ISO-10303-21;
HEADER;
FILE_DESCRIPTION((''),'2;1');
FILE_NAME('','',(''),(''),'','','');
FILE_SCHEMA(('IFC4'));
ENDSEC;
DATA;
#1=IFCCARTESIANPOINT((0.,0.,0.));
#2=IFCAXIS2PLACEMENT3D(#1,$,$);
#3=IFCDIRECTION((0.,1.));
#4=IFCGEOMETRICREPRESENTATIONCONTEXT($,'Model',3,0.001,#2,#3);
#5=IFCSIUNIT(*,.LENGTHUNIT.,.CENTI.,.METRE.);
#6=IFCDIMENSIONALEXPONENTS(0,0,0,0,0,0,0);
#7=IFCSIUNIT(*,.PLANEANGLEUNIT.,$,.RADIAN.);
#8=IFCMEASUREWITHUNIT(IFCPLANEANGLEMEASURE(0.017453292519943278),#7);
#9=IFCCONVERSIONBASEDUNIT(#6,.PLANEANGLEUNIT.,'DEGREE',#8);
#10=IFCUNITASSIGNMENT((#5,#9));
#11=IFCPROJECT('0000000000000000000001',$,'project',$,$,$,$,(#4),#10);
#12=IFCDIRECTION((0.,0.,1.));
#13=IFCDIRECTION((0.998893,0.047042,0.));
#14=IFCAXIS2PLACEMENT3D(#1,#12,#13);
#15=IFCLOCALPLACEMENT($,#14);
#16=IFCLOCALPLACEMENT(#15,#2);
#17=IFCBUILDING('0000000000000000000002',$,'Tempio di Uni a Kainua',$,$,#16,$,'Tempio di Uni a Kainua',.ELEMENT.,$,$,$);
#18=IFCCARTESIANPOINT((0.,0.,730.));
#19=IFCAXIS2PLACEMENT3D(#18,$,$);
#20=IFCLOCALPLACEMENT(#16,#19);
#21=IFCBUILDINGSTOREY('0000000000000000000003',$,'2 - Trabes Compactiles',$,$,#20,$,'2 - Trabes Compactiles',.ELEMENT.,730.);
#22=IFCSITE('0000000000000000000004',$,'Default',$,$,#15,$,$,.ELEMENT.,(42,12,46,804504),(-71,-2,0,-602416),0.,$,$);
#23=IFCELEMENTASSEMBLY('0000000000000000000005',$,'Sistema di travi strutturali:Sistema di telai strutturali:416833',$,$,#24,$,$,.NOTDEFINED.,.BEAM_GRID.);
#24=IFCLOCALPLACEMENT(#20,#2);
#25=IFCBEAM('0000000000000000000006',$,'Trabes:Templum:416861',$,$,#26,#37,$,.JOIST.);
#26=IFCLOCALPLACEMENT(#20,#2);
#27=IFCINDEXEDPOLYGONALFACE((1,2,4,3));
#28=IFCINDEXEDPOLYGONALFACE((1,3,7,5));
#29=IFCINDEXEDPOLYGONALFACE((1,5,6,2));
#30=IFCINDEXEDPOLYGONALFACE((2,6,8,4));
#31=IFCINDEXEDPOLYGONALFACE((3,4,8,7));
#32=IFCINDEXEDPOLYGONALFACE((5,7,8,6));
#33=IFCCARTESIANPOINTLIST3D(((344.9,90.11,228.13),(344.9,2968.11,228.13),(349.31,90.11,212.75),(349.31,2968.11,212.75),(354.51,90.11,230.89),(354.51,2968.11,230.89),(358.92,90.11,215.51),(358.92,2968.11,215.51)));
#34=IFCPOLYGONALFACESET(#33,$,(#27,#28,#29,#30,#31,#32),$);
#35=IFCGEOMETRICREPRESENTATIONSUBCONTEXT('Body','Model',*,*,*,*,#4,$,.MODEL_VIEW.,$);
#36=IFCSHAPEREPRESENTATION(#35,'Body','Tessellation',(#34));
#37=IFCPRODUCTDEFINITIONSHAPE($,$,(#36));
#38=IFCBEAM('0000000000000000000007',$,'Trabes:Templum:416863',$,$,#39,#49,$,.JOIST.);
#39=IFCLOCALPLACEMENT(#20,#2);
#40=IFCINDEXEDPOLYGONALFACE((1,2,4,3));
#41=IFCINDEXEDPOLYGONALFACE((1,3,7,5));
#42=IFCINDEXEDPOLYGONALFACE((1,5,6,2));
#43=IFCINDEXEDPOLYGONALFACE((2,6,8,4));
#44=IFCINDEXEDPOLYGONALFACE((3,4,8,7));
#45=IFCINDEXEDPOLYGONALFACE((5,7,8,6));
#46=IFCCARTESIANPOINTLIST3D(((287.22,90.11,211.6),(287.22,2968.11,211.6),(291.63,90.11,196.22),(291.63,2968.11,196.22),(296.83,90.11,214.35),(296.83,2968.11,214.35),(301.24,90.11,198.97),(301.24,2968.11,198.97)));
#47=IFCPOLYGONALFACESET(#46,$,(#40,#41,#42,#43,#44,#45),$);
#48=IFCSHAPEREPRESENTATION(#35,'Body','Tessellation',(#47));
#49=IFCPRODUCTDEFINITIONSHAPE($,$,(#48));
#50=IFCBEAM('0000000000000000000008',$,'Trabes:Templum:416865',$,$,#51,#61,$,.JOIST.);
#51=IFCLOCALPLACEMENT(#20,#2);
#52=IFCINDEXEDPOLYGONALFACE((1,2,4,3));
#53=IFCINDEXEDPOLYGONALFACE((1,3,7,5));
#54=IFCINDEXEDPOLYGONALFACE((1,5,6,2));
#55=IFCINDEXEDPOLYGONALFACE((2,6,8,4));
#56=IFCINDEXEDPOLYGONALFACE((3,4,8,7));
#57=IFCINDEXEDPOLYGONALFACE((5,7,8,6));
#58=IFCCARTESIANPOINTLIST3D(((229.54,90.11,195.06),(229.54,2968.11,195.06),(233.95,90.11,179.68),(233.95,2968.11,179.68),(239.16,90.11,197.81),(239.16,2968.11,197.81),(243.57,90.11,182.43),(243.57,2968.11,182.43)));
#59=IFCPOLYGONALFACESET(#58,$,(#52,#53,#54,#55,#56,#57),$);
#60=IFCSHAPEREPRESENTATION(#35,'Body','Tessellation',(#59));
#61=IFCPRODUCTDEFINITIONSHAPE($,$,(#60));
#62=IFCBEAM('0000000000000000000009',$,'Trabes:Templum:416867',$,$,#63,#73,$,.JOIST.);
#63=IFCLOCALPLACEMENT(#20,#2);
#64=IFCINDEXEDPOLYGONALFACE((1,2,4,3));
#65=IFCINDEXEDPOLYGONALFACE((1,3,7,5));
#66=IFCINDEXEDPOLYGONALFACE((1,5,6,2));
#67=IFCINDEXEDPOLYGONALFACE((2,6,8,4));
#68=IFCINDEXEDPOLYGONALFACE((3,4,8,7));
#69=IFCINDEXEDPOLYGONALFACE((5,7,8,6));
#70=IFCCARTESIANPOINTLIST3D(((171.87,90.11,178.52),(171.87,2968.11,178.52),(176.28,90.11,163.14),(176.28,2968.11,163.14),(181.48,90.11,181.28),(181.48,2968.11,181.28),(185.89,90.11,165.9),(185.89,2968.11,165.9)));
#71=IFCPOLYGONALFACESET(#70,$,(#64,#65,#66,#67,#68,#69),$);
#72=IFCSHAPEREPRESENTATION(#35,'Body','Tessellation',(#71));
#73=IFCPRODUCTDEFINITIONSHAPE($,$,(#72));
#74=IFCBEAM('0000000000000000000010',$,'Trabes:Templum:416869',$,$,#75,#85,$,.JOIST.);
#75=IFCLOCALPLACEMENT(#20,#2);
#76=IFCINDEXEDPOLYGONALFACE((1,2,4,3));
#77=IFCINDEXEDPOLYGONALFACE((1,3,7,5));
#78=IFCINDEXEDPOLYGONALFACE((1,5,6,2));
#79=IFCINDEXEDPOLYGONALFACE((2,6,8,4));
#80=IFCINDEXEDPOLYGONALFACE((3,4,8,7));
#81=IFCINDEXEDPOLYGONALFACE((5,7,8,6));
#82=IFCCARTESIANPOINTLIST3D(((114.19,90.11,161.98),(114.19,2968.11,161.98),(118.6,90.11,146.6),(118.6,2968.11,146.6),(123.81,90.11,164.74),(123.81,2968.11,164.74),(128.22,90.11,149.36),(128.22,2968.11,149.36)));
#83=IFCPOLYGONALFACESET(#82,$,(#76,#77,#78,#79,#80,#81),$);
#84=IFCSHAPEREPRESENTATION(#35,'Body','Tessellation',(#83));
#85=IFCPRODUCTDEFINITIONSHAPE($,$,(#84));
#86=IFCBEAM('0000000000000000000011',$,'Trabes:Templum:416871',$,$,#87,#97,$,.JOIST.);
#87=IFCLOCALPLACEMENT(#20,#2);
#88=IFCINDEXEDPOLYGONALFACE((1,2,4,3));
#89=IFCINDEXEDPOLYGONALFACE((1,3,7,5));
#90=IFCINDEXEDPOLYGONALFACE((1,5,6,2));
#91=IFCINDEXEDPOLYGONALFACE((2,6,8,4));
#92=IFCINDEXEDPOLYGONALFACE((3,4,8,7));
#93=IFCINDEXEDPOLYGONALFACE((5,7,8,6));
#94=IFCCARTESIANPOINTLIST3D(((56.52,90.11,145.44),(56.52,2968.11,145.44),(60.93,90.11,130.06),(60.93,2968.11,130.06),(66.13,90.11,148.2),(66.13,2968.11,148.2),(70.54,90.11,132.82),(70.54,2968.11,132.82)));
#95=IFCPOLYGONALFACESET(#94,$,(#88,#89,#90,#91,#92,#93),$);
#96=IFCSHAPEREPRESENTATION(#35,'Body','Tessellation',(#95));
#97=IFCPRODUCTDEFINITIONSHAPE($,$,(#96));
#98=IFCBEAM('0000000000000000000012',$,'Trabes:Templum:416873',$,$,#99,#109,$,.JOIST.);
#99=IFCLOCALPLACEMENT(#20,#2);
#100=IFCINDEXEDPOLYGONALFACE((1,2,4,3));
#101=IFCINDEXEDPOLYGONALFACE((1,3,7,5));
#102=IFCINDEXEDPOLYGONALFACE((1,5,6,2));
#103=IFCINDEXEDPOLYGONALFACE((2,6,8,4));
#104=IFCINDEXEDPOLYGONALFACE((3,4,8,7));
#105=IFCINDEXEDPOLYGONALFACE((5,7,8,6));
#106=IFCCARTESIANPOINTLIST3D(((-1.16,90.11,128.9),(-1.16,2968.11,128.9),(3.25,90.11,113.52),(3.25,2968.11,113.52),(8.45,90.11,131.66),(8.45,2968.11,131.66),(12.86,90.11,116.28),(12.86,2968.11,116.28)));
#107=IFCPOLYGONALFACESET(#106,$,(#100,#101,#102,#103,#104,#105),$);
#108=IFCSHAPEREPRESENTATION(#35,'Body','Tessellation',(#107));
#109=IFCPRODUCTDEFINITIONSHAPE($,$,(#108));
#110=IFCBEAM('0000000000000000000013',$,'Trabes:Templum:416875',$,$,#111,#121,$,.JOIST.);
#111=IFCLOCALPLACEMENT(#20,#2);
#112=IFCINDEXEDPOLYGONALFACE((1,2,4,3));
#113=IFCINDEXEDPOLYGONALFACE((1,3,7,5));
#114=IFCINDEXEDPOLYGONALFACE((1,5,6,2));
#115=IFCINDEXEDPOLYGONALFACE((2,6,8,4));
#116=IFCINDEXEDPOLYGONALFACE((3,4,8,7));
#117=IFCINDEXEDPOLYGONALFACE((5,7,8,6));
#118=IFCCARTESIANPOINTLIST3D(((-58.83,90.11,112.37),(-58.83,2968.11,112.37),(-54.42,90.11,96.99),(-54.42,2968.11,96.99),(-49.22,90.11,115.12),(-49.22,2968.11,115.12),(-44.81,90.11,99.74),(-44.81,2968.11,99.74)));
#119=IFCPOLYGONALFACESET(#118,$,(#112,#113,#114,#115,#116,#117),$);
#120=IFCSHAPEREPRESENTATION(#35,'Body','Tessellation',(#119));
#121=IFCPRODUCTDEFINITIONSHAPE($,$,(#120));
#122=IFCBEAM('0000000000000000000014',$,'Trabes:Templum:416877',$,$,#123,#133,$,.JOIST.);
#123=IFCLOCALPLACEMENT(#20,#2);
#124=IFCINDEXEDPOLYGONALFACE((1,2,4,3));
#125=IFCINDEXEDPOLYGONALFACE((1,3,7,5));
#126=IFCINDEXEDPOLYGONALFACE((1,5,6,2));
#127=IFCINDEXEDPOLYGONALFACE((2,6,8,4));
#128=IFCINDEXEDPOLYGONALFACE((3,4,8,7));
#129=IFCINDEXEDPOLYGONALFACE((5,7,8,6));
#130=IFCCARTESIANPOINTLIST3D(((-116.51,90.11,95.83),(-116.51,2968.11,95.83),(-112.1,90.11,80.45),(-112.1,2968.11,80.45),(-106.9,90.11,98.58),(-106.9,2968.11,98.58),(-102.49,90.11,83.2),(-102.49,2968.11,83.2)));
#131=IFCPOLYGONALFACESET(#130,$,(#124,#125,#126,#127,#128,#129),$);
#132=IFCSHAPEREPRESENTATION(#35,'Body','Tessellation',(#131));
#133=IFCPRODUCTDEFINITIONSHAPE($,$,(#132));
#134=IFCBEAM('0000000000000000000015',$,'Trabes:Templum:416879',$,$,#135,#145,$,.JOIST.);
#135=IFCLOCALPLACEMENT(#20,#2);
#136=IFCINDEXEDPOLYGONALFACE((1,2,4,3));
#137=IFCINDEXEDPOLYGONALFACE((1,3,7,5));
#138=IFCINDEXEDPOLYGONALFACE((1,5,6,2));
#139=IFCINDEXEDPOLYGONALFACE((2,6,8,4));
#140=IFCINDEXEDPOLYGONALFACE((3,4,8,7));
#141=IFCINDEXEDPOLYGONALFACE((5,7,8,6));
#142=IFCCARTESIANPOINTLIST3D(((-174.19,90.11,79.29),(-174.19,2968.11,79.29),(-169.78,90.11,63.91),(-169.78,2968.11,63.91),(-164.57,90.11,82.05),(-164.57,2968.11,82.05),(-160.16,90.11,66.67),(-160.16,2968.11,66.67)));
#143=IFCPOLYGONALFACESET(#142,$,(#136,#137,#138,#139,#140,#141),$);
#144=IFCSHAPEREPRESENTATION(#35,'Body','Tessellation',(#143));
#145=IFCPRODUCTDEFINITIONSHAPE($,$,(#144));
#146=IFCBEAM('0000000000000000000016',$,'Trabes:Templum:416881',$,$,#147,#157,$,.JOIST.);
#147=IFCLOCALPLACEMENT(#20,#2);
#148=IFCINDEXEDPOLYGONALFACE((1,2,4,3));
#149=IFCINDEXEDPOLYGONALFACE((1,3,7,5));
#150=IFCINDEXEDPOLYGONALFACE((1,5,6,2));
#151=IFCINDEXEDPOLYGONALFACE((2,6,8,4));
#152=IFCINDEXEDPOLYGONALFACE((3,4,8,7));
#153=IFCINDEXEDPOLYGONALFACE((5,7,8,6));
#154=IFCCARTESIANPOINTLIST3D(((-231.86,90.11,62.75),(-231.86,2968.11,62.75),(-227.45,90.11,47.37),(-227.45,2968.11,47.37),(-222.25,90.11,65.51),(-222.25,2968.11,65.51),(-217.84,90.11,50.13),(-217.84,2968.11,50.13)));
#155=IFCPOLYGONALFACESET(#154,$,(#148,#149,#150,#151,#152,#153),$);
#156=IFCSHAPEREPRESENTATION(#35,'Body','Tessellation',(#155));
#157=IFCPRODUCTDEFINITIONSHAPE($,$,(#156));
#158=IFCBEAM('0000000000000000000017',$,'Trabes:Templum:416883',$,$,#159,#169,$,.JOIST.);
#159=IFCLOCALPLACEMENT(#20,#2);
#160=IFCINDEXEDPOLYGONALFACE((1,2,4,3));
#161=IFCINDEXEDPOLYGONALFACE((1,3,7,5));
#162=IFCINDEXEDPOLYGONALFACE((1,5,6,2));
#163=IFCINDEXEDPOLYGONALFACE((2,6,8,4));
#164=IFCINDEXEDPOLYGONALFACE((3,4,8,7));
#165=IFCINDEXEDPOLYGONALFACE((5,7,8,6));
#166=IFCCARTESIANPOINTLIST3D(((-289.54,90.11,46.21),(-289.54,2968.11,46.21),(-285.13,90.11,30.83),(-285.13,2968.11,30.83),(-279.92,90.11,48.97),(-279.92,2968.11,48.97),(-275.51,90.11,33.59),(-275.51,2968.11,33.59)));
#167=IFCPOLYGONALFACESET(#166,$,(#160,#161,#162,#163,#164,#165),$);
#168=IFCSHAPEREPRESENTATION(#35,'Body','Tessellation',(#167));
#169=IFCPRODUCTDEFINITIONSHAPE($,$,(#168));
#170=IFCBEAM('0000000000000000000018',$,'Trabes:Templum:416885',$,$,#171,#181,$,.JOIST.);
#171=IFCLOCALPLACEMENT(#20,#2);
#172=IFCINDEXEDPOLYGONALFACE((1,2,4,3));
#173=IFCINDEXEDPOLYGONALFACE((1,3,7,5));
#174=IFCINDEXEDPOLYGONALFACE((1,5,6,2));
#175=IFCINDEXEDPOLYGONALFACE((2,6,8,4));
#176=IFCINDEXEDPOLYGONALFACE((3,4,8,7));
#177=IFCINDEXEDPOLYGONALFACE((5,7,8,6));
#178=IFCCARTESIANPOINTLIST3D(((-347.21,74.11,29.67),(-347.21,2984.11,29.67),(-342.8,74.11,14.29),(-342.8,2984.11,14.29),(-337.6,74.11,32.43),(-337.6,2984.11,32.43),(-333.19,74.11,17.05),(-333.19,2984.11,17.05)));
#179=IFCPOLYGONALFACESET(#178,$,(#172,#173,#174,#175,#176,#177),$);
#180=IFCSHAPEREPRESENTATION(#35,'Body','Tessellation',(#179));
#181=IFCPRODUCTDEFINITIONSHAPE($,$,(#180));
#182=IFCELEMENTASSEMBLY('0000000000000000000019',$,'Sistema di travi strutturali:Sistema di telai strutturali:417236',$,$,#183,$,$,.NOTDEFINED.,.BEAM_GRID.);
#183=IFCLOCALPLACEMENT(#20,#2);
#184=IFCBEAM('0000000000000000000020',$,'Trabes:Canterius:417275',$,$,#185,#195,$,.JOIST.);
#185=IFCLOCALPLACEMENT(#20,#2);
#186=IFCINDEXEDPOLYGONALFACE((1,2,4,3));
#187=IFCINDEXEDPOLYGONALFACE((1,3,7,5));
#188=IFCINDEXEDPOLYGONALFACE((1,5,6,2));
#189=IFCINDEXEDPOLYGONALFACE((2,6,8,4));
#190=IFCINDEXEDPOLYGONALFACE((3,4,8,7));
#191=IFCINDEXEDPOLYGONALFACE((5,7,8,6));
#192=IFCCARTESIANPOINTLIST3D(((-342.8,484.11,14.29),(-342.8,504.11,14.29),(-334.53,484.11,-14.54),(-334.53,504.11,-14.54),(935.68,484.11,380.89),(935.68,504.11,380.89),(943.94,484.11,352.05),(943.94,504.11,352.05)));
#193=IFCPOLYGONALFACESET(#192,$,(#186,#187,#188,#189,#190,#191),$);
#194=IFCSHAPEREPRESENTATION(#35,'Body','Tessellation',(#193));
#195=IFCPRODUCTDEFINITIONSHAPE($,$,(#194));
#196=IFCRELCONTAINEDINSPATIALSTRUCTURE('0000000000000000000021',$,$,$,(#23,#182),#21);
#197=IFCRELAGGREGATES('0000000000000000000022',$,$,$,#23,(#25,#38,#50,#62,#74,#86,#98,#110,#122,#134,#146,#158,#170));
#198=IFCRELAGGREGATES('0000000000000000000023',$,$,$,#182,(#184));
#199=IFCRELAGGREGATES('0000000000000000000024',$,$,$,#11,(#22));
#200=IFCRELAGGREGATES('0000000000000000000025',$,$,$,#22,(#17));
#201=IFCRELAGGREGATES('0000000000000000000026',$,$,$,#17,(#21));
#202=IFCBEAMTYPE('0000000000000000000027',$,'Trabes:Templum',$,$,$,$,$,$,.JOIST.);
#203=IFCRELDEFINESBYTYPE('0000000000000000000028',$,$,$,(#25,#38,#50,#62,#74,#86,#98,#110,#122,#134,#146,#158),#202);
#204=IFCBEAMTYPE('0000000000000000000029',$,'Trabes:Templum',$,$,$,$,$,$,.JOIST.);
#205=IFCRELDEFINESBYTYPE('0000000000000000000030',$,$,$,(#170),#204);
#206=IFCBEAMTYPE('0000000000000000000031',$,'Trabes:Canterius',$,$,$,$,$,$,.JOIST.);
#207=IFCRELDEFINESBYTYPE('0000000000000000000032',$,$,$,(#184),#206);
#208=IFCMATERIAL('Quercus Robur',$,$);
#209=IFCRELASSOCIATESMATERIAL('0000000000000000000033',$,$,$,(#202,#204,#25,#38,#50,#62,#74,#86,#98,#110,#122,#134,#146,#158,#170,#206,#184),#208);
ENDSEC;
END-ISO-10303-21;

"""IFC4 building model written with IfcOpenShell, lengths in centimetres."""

from ifc_helpers import new_model, entity, si_unit, converted_unit, direction, frame, frame_2d, origin, origin_2d_with_axis, place, context, subcontext, project, spatial, rectangle, extrude, source, transform, mapped, material, material_profile, profile_set, profile_usage, type_object, type_shapes, element, aggregate, save


model = new_model("IFC4")

# Units and contexts
model_context = context("Model", 3, precision=0.001, world=origin(), true_north=direction((0.0, 1.0)))
body_context = subcontext(model_context, "Body", "Model", "MODEL_VIEW")
ifc_project = project(units=[si_unit("LENGTHUNIT", "METRE", prefix="CENTI"), converted_unit("PLANEANGLEUNIT", "DEGREE", entity("IfcPlaneAngleMeasure", 0.017453292519943278), si_unit("PLANEANGLEUNIT", "RADIAN"), dimensions=[0, 0, 0, 0, 0, 0, 0])], contexts=[model_context])

# Site, building, storey
site_placement = place(None, frame((0.0, 0.0, 0.0), z_axis=(0.0, 0.0, 1.0), x_axis=(0.998893, 0.047042, 0.0)))
site = spatial("IfcSite", under=ifc_project, at=site_placement, Name="Default", CompositionType="ELEMENT", RefLatitude=(42, 12, 46, 804504), RefLongitude=(-71, -2, 0, -602416), RefElevation=0.0)
building_placement = place(site_placement, origin())
building = spatial("IfcBuilding", under=site, at=building_placement, Name="Tempio di Uni a Kainua", LongName="Tempio di Uni a Kainua", CompositionType="ELEMENT")
storey_placement = place(building_placement, frame((0.0, 0.0, 730.0)))
storey = spatial("IfcBuildingStorey", under=building, at=storey_placement, Name="2 - Trabes Compactiles", LongName="2 - Trabes Compactiles", CompositionType="ELEMENT", Elevation=730.0)

# Element assemblies, beams
assembly_1_placement = place(storey_placement, origin())
assembly_1 = element("IfcElementAssembly", 1, at=assembly_1_placement, inside=storey, Name="Sistema di travi strutturali:Sistema di telai strutturali:416833", AssemblyPlace="NOTDEFINED", PredefinedType="BEAM_GRID")
ifc_material_1 = material(Name="Quercus Robur")
ifc_material_profile_1 = material_profile(ifc_material_1, rectangle(XDim=2875.46, YDim=10.0, at=origin_2d_with_axis()), Name="Templum")
ifc_profile_set_1 = profile_set([ifc_material_profile_1], Name="Templum")
ifc_profile_usage_1 = profile_usage(ifc_profile_set_1, cardinal=2)
beam_type_1 = type_object("IfcBeamType", Name="Trabes:Templum", PredefinedType="JOIST", material=ifc_profile_set_1)
shared_shape_1 = source(origin(), body_context, "Body", "SweptSolid", [
    extrude(rectangle(XDim=2878.0, YDim=10.0, at=frame_2d((0.0, 0.0), x_axis=(1.0, 0.0))), frame((0.0, 0.0, -8.0)), (0.0, 0.0, 1.0), 16.0),
])
type_shapes(beam_type_1, [shared_shape_1])
beam_1_placement = place(assembly_1_placement, frame((351.91, 1529.11, 221.82), z_axis=(-0.275637, 0.0, 0.961262), x_axis=(0.0, 1.0, 0.0)))
beam_1 = element("IfcBeam", 2, at=beam_1_placement, type_object=beam_type_1, material=ifc_profile_usage_1, Name="Trabes:Templum:416861", PredefinedType="JOIST", context=body_context, shape_type="MappedRepresentation", body=[
    mapped(shared_shape_1, transform((0.0, 0.0, 0.0), scale=1.0)),
])
beam_2_placement = place(assembly_1_placement, frame((294.23, 1529.11, 205.28), z_axis=(-0.275637, 0.0, 0.961262), x_axis=(0.0, 1.0, 0.0)))
beam_2 = element("IfcBeam", 3, at=beam_2_placement, type_object=beam_type_1, material=ifc_profile_usage_1, Name="Trabes:Templum:416863", PredefinedType="JOIST", context=body_context, shape_type="MappedRepresentation", body=[
    mapped(shared_shape_1, transform((0.0, 0.0, 0.0), scale=1.0)),
])
beam_3_placement = place(assembly_1_placement, frame((236.56, 1529.11, 188.75), z_axis=(-0.275637, 0.0, 0.961262), x_axis=(0.0, 1.0, 0.0)))
beam_3 = element("IfcBeam", 4, at=beam_3_placement, type_object=beam_type_1, material=ifc_profile_usage_1, Name="Trabes:Templum:416865", PredefinedType="JOIST", context=body_context, shape_type="MappedRepresentation", body=[
    mapped(shared_shape_1, transform((0.0, 0.0, 0.0), scale=1.0)),
])
beam_4_placement = place(assembly_1_placement, frame((178.88, 1529.11, 172.21), z_axis=(-0.275637, 0.0, 0.961262), x_axis=(0.0, 1.0, 0.0)))
beam_4 = element("IfcBeam", 5, at=beam_4_placement, type_object=beam_type_1, material=ifc_profile_usage_1, Name="Trabes:Templum:416867", PredefinedType="JOIST", context=body_context, shape_type="MappedRepresentation", body=[
    mapped(shared_shape_1, transform((0.0, 0.0, 0.0), scale=1.0)),
])
beam_5_placement = place(assembly_1_placement, frame((121.2, 1529.11, 155.67), z_axis=(-0.275637, 0.0, 0.961262), x_axis=(0.0, 1.0, 0.0)))
beam_5 = element("IfcBeam", 6, at=beam_5_placement, type_object=beam_type_1, material=ifc_profile_usage_1, Name="Trabes:Templum:416869", PredefinedType="JOIST", context=body_context, shape_type="MappedRepresentation", body=[
    mapped(shared_shape_1, transform((0.0, 0.0, 0.0), scale=1.0)),
])
beam_6_placement = place(assembly_1_placement, frame((63.53, 1529.11, 139.13), z_axis=(-0.275637, 0.0, 0.961262), x_axis=(0.0, 1.0, 0.0)))
beam_6 = element("IfcBeam", 7, at=beam_6_placement, type_object=beam_type_1, material=ifc_profile_usage_1, Name="Trabes:Templum:416871", PredefinedType="JOIST", context=body_context, shape_type="MappedRepresentation", body=[
    mapped(shared_shape_1, transform((0.0, 0.0, 0.0), scale=1.0)),
])
beam_7_placement = place(assembly_1_placement, frame((5.85, 1529.11, 122.59), z_axis=(-0.275637, 0.0, 0.961262), x_axis=(0.0, 1.0, 0.0)))
beam_7 = element("IfcBeam", 8, at=beam_7_placement, type_object=beam_type_1, material=ifc_profile_usage_1, Name="Trabes:Templum:416873", PredefinedType="JOIST", context=body_context, shape_type="MappedRepresentation", body=[
    mapped(shared_shape_1, transform((0.0, 0.0, 0.0), scale=1.0)),
])
beam_8_placement = place(assembly_1_placement, frame((-51.82, 1529.11, 106.05), z_axis=(-0.275637, 0.0, 0.961262), x_axis=(0.0, 1.0, 0.0)))
beam_8 = element("IfcBeam", 9, at=beam_8_placement, type_object=beam_type_1, material=ifc_profile_usage_1, Name="Trabes:Templum:416875", PredefinedType="JOIST", context=body_context, shape_type="MappedRepresentation", body=[
    mapped(shared_shape_1, transform((0.0, 0.0, 0.0), scale=1.0)),
])
beam_9_placement = place(assembly_1_placement, frame((-109.5, 1529.11, 89.52), z_axis=(-0.275637, 0.0, 0.961262), x_axis=(0.0, 1.0, 0.0)))
beam_9 = element("IfcBeam", 10, at=beam_9_placement, type_object=beam_type_1, material=ifc_profile_usage_1, Name="Trabes:Templum:416877", PredefinedType="JOIST", context=body_context, shape_type="MappedRepresentation", body=[
    mapped(shared_shape_1, transform((0.0, 0.0, 0.0), scale=1.0)),
])
beam_10_placement = place(assembly_1_placement, frame((-167.17, 1529.11, 72.98), z_axis=(-0.275637, 0.0, 0.961262), x_axis=(0.0, 1.0, 0.0)))
beam_10 = element("IfcBeam", 11, at=beam_10_placement, type_object=beam_type_1, material=ifc_profile_usage_1, Name="Trabes:Templum:416879", PredefinedType="JOIST", context=body_context, shape_type="MappedRepresentation", body=[
    mapped(shared_shape_1, transform((0.0, 0.0, 0.0), scale=1.0)),
])
beam_11_placement = place(assembly_1_placement, frame((-224.85, 1529.11, 56.44), z_axis=(-0.275637, 0.0, 0.961262), x_axis=(0.0, 1.0, 0.0)))
beam_11 = element("IfcBeam", 12, at=beam_11_placement, type_object=beam_type_1, material=ifc_profile_usage_1, Name="Trabes:Templum:416881", PredefinedType="JOIST", context=body_context, shape_type="MappedRepresentation", body=[
    mapped(shared_shape_1, transform((0.0, 0.0, 0.0), scale=1.0)),
])
beam_12_placement = place(assembly_1_placement, frame((-282.53, 1529.11, 39.9), z_axis=(-0.275637, 0.0, 0.961262), x_axis=(0.0, 1.0, 0.0)))
beam_12 = element("IfcBeam", 13, at=beam_12_placement, type_object=beam_type_1, material=ifc_profile_usage_1, Name="Trabes:Templum:416883", PredefinedType="JOIST", context=body_context, shape_type="MappedRepresentation", body=[
    mapped(shared_shape_1, transform((0.0, 0.0, 0.0), scale=1.0)),
])
beam_type_2 = type_object("IfcBeamType", Name="Trabes:Templum", PredefinedType="JOIST", material=ifc_profile_set_1)
shared_shape_2 = source(origin(), body_context, "Body", "SweptSolid", [
    extrude(rectangle(XDim=2910.0, YDim=10.0, at=origin_2d_with_axis()), frame((0.0, 0.0, -8.0)), (0.0, 0.0, 1.0), 16.0),
])
type_shapes(beam_type_2, [shared_shape_2])
beam_13_placement = place(assembly_1_placement, frame((-340.2, 1529.11, 23.36), z_axis=(-0.275637, 0.0, 0.961262), x_axis=(0.0, 1.0, 0.0)))
beam_13 = element("IfcBeam", 14, at=beam_13_placement, type_object=beam_type_2, material=ifc_profile_usage_1, Name="Trabes:Templum:416885", PredefinedType="JOIST", context=body_context, shape_type="MappedRepresentation", body=[
    mapped(shared_shape_2, transform((0.0, 0.0, 0.0), scale=1.0)),
])
aggregate(assembly_1, [beam_1, beam_2, beam_3, beam_4, beam_5, beam_6, beam_7, beam_8, beam_9, beam_10, beam_11, beam_12, beam_13])
assembly_2_placement = place(storey_placement, origin())
assembly_2 = element("IfcElementAssembly", 15, at=assembly_2_placement, inside=storey, Name="Sistema di travi strutturali:Sistema di telai strutturali:417236", AssemblyPlace="NOTDEFINED", PredefinedType="BEAM_GRID")
ifc_material_profile_2 = material_profile(ifc_material_1, rectangle(XDim=2590.0, YDim=20.0, at=origin_2d_with_axis()), Name="Canterius")
ifc_profile_set_2 = profile_set([ifc_material_profile_2], Name="Canterius")
ifc_profile_usage_2 = profile_usage(ifc_profile_set_2, cardinal=8)
beam_type_3 = type_object("IfcBeamType", Name="Trabes:Canterius", PredefinedType="JOIST", material=ifc_profile_set_2)
shared_shape_3 = source(origin(), body_context, "Body", "SweptSolid", [
    extrude(rectangle(XDim=1330.0, YDim=20.0, at=origin_2d_with_axis()), frame((0.0, 0.0, -15.0)), (0.0, 0.0, 1.0), 30.0),
])
type_shapes(beam_type_3, [shared_shape_3])
beam_14_placement = place(assembly_2_placement, frame((300.57, 494.11, 183.17), z_axis=(-0.275637, 0.0, 0.961262), x_axis=(0.961262, 0.0, 0.275637)))
beam_14 = element("IfcBeam", 16, at=beam_14_placement, type_object=beam_type_3, material=ifc_profile_usage_2, Name="Trabes:Canterius:417275", PredefinedType="JOIST", context=body_context, shape_type="MappedRepresentation", body=[
    mapped(shared_shape_3, transform((0.0, 0.0, 0.0), scale=1.0)),
])
aggregate(assembly_2, [beam_14])

save(model, "model.ifc")
